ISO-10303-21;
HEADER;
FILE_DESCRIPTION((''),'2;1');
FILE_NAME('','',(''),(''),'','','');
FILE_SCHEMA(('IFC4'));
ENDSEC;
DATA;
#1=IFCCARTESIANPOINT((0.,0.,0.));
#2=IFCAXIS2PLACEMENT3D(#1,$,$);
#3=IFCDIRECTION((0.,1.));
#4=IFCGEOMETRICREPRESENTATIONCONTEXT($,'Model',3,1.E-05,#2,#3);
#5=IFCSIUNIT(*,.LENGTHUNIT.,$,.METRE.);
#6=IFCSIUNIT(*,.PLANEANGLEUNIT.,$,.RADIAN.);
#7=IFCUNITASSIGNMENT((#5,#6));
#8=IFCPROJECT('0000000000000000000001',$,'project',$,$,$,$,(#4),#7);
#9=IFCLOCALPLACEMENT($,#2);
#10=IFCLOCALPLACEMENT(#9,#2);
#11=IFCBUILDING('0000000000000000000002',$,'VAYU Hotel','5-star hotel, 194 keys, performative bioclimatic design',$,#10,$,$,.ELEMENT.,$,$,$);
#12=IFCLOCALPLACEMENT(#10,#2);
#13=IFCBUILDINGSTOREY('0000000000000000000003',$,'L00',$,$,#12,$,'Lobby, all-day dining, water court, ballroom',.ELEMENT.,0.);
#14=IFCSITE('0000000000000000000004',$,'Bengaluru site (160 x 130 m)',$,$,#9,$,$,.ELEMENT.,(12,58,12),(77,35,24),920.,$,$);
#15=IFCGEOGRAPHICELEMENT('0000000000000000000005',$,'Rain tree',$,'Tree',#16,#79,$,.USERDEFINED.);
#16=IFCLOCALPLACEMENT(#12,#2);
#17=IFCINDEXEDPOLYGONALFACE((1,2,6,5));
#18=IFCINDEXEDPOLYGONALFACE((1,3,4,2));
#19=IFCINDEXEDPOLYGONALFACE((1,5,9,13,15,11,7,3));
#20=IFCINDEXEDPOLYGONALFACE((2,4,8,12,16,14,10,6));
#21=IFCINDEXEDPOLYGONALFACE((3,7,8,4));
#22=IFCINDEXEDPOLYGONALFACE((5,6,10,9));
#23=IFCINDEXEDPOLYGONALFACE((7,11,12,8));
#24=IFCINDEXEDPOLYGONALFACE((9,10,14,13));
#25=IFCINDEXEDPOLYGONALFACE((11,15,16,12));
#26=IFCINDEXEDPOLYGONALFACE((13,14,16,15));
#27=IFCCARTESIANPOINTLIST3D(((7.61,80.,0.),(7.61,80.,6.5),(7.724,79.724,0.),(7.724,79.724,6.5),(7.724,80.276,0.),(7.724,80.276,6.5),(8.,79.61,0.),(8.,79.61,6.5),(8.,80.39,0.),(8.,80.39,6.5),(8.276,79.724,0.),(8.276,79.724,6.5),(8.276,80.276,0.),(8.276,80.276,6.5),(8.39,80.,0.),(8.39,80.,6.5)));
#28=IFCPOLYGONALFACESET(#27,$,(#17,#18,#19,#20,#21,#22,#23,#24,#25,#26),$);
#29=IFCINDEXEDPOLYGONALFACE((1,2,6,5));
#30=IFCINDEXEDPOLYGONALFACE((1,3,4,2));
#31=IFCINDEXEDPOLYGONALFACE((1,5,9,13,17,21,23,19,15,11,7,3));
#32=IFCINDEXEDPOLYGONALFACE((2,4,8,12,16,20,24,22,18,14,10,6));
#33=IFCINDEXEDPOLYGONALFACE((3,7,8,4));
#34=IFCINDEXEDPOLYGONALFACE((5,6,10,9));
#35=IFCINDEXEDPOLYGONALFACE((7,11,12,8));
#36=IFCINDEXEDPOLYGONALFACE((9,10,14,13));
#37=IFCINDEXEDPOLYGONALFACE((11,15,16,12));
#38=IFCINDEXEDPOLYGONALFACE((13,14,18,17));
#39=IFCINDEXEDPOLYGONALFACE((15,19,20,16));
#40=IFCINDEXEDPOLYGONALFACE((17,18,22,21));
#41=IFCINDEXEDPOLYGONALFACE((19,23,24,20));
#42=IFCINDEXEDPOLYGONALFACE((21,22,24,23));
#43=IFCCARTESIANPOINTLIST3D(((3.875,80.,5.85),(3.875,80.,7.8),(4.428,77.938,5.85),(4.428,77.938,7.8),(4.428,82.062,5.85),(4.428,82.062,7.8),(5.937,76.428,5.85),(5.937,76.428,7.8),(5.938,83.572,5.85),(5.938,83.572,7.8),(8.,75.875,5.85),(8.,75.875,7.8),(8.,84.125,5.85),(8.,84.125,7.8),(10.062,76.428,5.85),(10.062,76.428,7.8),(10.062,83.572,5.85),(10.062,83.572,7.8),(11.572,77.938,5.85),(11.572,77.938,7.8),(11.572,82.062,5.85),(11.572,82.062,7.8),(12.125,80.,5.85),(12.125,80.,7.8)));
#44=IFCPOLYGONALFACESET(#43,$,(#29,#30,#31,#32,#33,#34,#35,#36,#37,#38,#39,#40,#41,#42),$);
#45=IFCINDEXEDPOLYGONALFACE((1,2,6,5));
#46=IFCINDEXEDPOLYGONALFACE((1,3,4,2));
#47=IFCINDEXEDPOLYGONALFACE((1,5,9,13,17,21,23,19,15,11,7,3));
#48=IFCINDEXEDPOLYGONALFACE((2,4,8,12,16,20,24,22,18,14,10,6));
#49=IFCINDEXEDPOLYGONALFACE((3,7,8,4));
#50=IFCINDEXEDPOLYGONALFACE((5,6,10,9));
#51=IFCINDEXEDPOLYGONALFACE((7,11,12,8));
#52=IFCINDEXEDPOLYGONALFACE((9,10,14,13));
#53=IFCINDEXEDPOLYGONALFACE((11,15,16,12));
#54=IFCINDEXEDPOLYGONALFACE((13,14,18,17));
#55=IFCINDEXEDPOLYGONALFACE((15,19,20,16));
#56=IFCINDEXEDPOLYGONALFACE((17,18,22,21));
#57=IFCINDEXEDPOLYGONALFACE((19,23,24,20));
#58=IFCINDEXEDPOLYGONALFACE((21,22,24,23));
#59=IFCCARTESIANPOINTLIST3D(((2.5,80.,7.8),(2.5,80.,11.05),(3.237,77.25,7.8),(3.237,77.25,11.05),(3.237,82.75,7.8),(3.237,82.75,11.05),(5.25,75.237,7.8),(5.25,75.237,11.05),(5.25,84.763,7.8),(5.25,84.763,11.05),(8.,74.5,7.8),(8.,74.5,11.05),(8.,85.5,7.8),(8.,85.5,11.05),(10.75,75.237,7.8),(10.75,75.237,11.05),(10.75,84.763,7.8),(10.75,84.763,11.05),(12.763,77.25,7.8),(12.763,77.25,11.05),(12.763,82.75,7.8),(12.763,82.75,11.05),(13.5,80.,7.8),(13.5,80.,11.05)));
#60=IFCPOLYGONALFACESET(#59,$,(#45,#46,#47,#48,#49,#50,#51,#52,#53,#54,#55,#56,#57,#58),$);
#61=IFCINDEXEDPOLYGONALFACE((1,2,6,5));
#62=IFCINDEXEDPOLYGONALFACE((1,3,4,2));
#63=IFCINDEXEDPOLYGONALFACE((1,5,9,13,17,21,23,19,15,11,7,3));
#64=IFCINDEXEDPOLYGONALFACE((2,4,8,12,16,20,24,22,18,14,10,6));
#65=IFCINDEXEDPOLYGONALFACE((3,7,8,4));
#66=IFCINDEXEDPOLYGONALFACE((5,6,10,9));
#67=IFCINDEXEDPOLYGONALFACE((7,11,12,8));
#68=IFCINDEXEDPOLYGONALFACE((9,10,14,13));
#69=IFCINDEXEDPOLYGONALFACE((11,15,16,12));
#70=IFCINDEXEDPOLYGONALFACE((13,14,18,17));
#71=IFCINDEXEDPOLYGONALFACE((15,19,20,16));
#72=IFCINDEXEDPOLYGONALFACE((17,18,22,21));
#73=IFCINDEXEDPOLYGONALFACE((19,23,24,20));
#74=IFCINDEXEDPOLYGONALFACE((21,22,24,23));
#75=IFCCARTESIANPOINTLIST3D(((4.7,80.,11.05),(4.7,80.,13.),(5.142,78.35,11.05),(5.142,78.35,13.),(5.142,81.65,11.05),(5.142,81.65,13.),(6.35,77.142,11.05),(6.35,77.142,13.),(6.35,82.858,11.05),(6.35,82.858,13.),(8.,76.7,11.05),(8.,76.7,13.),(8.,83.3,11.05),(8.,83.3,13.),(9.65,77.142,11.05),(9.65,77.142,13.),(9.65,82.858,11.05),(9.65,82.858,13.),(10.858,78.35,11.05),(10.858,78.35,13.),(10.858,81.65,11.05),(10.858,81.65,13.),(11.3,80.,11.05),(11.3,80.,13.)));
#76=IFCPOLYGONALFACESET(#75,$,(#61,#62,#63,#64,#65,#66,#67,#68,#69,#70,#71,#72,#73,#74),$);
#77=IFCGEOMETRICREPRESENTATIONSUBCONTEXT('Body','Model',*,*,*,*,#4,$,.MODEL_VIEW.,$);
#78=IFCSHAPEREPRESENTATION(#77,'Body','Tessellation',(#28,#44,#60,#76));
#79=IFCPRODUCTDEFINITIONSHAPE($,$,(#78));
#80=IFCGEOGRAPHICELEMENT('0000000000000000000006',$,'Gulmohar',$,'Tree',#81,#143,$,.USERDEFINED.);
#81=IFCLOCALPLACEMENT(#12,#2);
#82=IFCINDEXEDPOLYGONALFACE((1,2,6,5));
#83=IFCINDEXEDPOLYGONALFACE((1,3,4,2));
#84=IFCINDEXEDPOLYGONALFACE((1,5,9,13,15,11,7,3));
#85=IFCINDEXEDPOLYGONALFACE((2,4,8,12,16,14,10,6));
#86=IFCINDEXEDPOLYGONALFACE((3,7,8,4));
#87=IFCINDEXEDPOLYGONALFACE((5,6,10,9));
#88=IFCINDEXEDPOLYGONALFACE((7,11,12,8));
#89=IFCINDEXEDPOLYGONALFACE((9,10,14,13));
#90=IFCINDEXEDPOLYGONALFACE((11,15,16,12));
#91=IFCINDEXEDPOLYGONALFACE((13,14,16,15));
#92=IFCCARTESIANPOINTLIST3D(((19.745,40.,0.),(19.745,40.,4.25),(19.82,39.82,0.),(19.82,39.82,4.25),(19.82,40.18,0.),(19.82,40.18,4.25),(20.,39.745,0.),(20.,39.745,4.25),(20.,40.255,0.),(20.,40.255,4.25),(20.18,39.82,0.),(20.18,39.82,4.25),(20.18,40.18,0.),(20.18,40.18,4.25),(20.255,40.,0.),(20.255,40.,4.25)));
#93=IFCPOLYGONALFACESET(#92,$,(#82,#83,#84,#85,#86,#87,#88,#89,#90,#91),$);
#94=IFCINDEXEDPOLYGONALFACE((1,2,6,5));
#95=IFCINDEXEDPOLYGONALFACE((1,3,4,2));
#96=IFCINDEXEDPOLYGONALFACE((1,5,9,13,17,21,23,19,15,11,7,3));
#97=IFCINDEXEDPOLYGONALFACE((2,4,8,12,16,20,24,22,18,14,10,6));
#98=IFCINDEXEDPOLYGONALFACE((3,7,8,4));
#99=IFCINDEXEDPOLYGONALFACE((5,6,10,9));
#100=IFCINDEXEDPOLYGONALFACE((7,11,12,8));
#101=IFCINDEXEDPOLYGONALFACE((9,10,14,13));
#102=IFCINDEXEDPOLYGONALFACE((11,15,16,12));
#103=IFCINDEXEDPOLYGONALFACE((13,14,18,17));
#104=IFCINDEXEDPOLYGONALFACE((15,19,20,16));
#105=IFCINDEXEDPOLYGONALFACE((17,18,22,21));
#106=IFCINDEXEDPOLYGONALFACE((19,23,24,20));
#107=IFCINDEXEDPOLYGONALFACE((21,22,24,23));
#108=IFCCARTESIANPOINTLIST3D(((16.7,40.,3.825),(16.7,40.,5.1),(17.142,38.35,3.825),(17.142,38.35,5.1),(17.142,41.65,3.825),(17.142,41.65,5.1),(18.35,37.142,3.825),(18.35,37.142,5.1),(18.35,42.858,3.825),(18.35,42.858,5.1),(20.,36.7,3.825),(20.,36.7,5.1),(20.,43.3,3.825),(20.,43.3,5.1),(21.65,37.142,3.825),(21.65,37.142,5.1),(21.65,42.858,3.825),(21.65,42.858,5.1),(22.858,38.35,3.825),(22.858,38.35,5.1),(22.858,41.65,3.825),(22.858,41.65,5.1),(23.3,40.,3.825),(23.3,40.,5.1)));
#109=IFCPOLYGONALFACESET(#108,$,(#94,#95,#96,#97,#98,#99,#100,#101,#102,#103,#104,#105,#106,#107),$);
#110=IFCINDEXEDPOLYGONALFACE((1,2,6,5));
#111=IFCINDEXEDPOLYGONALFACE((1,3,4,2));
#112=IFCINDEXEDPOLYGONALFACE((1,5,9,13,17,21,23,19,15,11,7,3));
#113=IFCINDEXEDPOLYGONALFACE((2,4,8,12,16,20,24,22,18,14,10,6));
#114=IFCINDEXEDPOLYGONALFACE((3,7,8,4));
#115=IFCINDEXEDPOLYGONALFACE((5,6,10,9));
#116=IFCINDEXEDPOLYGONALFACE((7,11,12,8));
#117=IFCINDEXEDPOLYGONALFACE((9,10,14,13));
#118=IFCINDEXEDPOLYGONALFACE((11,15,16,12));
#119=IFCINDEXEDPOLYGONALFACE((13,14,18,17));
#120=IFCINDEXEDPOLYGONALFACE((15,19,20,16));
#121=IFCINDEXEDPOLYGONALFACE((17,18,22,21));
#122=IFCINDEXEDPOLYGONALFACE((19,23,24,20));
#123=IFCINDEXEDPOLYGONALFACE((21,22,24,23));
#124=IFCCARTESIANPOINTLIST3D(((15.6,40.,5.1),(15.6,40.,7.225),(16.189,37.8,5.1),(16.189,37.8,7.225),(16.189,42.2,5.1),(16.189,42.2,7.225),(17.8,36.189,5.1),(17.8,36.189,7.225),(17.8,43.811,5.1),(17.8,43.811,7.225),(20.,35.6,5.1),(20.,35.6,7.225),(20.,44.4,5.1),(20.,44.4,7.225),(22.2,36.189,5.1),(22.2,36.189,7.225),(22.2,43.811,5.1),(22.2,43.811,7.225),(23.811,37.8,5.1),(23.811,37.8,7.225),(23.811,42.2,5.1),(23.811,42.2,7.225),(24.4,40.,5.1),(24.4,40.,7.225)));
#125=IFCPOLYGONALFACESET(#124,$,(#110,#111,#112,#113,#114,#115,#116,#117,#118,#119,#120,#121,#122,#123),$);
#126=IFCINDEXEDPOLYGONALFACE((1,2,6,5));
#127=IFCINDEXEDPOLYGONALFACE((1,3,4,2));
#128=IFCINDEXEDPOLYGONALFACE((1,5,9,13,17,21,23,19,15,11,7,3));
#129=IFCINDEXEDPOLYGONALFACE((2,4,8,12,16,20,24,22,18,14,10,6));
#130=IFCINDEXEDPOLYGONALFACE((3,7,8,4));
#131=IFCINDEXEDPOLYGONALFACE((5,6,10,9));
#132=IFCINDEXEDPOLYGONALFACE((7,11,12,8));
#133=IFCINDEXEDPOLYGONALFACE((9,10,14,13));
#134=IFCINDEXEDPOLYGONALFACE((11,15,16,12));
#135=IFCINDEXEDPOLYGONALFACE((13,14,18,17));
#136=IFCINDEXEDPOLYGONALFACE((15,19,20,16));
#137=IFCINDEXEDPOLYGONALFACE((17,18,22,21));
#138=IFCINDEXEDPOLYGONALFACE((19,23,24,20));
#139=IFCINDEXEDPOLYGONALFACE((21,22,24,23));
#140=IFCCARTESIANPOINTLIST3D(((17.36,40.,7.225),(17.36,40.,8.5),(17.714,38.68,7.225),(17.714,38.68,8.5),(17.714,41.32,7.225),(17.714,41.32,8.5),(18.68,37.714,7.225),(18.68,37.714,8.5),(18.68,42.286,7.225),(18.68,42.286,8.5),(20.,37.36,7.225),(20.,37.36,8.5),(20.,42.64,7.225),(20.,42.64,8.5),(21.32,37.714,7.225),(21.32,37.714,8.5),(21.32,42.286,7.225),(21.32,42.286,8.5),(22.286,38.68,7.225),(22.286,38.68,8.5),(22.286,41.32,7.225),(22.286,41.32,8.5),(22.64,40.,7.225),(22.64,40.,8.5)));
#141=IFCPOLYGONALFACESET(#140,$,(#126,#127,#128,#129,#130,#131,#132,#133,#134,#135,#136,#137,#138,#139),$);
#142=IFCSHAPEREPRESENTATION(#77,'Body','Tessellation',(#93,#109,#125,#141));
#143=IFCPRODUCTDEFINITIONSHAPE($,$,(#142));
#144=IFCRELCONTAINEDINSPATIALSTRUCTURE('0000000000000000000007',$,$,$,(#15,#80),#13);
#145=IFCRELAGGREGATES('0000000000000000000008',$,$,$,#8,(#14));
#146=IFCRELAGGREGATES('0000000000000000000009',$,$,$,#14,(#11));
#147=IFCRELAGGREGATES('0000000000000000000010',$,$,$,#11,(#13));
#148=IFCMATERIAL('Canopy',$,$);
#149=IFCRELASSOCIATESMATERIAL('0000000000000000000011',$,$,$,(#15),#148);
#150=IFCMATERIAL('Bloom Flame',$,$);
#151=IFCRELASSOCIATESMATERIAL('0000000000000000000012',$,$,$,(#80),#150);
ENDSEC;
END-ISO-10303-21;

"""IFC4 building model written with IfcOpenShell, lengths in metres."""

from ifc_helpers import new_model, si_unit, direction, frame, origin, place, context, subcontext, project, spatial, polyline, outline, extrude, material, element, save


model = new_model("IFC4")

# Units and contexts
model_context = context("Model", 3, precision=1e-05, world=origin(), true_north=direction((0.0, 1.0)))
body_context = subcontext(model_context, "Body", "Model", "MODEL_VIEW")
ifc_project = project(units=[si_unit("LENGTHUNIT", "METRE"), si_unit("PLANEANGLEUNIT", "RADIAN")], contexts=[model_context])

# Site, building, storey
site_placement = place(None, origin())
site = spatial("IfcSite", under=ifc_project, at=site_placement, Name="Bengaluru site (160 x 130 m)", CompositionType="ELEMENT", RefLatitude=(12, 58, 12), RefLongitude=(77, 35, 24), RefElevation=920.0)
building_placement = place(site_placement, origin())
building = spatial("IfcBuilding", under=site, at=building_placement, Name="VAYU Hotel", Description="5-star hotel, 194 keys, performative bioclimatic design", CompositionType="ELEMENT")
storey_placement = place(building_placement, origin())
storey = spatial("IfcBuildingStorey", under=building, at=storey_placement, Name="L00", LongName="Lobby, all-day dining, water court, ballroom", CompositionType="ELEMENT", Elevation=0.0)

# Geographic elements
ifc_material_1 = material(Name="Canopy")
geographic_element_1_placement = place(storey_placement, origin())
element("IfcGeographicElement", 1, at=geographic_element_1_placement, inside=storey, material=ifc_material_1, Name="Rain tree", ObjectType="Tree", PredefinedType="USERDEFINED", context=body_context, shape_type="SweptSolid", body=[
    extrude(outline(polyline([(8.39, 80.0), (8.276, 80.276), (8.0, 80.39), (7.724, 80.276), (7.61, 80.0), (7.724, 79.724), (8.0, 79.61), (8.276, 79.724), (8.39, 80.0)])), origin(), (0.0, 0.0, 1.0), 6.5),
    extrude(outline(polyline([(12.125, 80.0), (11.572, 82.062), (10.062, 83.572), (8.0, 84.125), (5.938, 83.572), (4.428, 82.062), (3.875, 80.0), (4.428, 77.938), (5.937, 76.428), (8.0, 75.875), (10.062, 76.428), (11.572, 77.938), (12.125, 80.0)])), frame((0.0, 0.0, 5.85)), (0.0, 0.0, 1.0), 1.95),
    extrude(outline(polyline([(13.5, 80.0), (12.763, 82.75), (10.75, 84.763), (8.0, 85.5), (5.25, 84.763), (3.237, 82.75), (2.5, 80.0), (3.237, 77.25), (5.25, 75.237), (8.0, 74.5), (10.75, 75.237), (12.763, 77.25), (13.5, 80.0)])), frame((0.0, 0.0, 7.8)), (0.0, 0.0, 1.0), 3.25),
    extrude(outline(polyline([(11.3, 80.0), (10.858, 81.65), (9.65, 82.858), (8.0, 83.3), (6.35, 82.858), (5.142, 81.65), (4.7, 80.0), (5.142, 78.35), (6.35, 77.142), (8.0, 76.7), (9.65, 77.142), (10.858, 78.35), (11.3, 80.0)])), frame((0.0, 0.0, 11.05)), (0.0, 0.0, 1.0), 1.95),
])
ifc_material_2 = material(Name="Bloom Flame")
geographic_element_2_placement = place(storey_placement, origin())
element("IfcGeographicElement", 2, at=geographic_element_2_placement, inside=storey, material=ifc_material_2, Name="Gulmohar", ObjectType="Tree", PredefinedType="USERDEFINED", context=body_context, shape_type="SweptSolid", body=[
    extrude(outline(polyline([(20.255, 40.0), (20.18, 40.18), (20.0, 40.255), (19.82, 40.18), (19.745, 40.0), (19.82, 39.82), (20.0, 39.745), (20.18, 39.82), (20.255, 40.0)])), origin(), (0.0, 0.0, 1.0), 4.25),
    extrude(outline(polyline([(23.3, 40.0), (22.858, 41.65), (21.65, 42.858), (20.0, 43.3), (18.35, 42.858), (17.142, 41.65), (16.7, 40.0), (17.142, 38.35), (18.35, 37.142), (20.0, 36.7), (21.65, 37.142), (22.858, 38.35), (23.3, 40.0)])), frame((0.0, 0.0, 3.825)), (0.0, 0.0, 1.0), 1.275),
    extrude(outline(polyline([(24.4, 40.0), (23.811, 42.2), (22.2, 43.811), (20.0, 44.4), (17.8, 43.811), (16.189, 42.2), (15.6, 40.0), (16.189, 37.8), (17.8, 36.189), (20.0, 35.6), (22.2, 36.189), (23.811, 37.8), (24.4, 40.0)])), frame((0.0, 0.0, 5.1)), (0.0, 0.0, 1.0), 2.125),
    extrude(outline(polyline([(22.64, 40.0), (22.286, 41.32), (21.32, 42.286), (20.0, 42.64), (18.68, 42.286), (17.714, 41.32), (17.36, 40.0), (17.714, 38.68), (18.68, 37.714), (20.0, 37.36), (21.32, 37.714), (22.286, 38.68), (22.64, 40.0)])), frame((0.0, 0.0, 7.225)), (0.0, 0.0, 1.0), 1.275),
])

save(model, "model.ifc")
